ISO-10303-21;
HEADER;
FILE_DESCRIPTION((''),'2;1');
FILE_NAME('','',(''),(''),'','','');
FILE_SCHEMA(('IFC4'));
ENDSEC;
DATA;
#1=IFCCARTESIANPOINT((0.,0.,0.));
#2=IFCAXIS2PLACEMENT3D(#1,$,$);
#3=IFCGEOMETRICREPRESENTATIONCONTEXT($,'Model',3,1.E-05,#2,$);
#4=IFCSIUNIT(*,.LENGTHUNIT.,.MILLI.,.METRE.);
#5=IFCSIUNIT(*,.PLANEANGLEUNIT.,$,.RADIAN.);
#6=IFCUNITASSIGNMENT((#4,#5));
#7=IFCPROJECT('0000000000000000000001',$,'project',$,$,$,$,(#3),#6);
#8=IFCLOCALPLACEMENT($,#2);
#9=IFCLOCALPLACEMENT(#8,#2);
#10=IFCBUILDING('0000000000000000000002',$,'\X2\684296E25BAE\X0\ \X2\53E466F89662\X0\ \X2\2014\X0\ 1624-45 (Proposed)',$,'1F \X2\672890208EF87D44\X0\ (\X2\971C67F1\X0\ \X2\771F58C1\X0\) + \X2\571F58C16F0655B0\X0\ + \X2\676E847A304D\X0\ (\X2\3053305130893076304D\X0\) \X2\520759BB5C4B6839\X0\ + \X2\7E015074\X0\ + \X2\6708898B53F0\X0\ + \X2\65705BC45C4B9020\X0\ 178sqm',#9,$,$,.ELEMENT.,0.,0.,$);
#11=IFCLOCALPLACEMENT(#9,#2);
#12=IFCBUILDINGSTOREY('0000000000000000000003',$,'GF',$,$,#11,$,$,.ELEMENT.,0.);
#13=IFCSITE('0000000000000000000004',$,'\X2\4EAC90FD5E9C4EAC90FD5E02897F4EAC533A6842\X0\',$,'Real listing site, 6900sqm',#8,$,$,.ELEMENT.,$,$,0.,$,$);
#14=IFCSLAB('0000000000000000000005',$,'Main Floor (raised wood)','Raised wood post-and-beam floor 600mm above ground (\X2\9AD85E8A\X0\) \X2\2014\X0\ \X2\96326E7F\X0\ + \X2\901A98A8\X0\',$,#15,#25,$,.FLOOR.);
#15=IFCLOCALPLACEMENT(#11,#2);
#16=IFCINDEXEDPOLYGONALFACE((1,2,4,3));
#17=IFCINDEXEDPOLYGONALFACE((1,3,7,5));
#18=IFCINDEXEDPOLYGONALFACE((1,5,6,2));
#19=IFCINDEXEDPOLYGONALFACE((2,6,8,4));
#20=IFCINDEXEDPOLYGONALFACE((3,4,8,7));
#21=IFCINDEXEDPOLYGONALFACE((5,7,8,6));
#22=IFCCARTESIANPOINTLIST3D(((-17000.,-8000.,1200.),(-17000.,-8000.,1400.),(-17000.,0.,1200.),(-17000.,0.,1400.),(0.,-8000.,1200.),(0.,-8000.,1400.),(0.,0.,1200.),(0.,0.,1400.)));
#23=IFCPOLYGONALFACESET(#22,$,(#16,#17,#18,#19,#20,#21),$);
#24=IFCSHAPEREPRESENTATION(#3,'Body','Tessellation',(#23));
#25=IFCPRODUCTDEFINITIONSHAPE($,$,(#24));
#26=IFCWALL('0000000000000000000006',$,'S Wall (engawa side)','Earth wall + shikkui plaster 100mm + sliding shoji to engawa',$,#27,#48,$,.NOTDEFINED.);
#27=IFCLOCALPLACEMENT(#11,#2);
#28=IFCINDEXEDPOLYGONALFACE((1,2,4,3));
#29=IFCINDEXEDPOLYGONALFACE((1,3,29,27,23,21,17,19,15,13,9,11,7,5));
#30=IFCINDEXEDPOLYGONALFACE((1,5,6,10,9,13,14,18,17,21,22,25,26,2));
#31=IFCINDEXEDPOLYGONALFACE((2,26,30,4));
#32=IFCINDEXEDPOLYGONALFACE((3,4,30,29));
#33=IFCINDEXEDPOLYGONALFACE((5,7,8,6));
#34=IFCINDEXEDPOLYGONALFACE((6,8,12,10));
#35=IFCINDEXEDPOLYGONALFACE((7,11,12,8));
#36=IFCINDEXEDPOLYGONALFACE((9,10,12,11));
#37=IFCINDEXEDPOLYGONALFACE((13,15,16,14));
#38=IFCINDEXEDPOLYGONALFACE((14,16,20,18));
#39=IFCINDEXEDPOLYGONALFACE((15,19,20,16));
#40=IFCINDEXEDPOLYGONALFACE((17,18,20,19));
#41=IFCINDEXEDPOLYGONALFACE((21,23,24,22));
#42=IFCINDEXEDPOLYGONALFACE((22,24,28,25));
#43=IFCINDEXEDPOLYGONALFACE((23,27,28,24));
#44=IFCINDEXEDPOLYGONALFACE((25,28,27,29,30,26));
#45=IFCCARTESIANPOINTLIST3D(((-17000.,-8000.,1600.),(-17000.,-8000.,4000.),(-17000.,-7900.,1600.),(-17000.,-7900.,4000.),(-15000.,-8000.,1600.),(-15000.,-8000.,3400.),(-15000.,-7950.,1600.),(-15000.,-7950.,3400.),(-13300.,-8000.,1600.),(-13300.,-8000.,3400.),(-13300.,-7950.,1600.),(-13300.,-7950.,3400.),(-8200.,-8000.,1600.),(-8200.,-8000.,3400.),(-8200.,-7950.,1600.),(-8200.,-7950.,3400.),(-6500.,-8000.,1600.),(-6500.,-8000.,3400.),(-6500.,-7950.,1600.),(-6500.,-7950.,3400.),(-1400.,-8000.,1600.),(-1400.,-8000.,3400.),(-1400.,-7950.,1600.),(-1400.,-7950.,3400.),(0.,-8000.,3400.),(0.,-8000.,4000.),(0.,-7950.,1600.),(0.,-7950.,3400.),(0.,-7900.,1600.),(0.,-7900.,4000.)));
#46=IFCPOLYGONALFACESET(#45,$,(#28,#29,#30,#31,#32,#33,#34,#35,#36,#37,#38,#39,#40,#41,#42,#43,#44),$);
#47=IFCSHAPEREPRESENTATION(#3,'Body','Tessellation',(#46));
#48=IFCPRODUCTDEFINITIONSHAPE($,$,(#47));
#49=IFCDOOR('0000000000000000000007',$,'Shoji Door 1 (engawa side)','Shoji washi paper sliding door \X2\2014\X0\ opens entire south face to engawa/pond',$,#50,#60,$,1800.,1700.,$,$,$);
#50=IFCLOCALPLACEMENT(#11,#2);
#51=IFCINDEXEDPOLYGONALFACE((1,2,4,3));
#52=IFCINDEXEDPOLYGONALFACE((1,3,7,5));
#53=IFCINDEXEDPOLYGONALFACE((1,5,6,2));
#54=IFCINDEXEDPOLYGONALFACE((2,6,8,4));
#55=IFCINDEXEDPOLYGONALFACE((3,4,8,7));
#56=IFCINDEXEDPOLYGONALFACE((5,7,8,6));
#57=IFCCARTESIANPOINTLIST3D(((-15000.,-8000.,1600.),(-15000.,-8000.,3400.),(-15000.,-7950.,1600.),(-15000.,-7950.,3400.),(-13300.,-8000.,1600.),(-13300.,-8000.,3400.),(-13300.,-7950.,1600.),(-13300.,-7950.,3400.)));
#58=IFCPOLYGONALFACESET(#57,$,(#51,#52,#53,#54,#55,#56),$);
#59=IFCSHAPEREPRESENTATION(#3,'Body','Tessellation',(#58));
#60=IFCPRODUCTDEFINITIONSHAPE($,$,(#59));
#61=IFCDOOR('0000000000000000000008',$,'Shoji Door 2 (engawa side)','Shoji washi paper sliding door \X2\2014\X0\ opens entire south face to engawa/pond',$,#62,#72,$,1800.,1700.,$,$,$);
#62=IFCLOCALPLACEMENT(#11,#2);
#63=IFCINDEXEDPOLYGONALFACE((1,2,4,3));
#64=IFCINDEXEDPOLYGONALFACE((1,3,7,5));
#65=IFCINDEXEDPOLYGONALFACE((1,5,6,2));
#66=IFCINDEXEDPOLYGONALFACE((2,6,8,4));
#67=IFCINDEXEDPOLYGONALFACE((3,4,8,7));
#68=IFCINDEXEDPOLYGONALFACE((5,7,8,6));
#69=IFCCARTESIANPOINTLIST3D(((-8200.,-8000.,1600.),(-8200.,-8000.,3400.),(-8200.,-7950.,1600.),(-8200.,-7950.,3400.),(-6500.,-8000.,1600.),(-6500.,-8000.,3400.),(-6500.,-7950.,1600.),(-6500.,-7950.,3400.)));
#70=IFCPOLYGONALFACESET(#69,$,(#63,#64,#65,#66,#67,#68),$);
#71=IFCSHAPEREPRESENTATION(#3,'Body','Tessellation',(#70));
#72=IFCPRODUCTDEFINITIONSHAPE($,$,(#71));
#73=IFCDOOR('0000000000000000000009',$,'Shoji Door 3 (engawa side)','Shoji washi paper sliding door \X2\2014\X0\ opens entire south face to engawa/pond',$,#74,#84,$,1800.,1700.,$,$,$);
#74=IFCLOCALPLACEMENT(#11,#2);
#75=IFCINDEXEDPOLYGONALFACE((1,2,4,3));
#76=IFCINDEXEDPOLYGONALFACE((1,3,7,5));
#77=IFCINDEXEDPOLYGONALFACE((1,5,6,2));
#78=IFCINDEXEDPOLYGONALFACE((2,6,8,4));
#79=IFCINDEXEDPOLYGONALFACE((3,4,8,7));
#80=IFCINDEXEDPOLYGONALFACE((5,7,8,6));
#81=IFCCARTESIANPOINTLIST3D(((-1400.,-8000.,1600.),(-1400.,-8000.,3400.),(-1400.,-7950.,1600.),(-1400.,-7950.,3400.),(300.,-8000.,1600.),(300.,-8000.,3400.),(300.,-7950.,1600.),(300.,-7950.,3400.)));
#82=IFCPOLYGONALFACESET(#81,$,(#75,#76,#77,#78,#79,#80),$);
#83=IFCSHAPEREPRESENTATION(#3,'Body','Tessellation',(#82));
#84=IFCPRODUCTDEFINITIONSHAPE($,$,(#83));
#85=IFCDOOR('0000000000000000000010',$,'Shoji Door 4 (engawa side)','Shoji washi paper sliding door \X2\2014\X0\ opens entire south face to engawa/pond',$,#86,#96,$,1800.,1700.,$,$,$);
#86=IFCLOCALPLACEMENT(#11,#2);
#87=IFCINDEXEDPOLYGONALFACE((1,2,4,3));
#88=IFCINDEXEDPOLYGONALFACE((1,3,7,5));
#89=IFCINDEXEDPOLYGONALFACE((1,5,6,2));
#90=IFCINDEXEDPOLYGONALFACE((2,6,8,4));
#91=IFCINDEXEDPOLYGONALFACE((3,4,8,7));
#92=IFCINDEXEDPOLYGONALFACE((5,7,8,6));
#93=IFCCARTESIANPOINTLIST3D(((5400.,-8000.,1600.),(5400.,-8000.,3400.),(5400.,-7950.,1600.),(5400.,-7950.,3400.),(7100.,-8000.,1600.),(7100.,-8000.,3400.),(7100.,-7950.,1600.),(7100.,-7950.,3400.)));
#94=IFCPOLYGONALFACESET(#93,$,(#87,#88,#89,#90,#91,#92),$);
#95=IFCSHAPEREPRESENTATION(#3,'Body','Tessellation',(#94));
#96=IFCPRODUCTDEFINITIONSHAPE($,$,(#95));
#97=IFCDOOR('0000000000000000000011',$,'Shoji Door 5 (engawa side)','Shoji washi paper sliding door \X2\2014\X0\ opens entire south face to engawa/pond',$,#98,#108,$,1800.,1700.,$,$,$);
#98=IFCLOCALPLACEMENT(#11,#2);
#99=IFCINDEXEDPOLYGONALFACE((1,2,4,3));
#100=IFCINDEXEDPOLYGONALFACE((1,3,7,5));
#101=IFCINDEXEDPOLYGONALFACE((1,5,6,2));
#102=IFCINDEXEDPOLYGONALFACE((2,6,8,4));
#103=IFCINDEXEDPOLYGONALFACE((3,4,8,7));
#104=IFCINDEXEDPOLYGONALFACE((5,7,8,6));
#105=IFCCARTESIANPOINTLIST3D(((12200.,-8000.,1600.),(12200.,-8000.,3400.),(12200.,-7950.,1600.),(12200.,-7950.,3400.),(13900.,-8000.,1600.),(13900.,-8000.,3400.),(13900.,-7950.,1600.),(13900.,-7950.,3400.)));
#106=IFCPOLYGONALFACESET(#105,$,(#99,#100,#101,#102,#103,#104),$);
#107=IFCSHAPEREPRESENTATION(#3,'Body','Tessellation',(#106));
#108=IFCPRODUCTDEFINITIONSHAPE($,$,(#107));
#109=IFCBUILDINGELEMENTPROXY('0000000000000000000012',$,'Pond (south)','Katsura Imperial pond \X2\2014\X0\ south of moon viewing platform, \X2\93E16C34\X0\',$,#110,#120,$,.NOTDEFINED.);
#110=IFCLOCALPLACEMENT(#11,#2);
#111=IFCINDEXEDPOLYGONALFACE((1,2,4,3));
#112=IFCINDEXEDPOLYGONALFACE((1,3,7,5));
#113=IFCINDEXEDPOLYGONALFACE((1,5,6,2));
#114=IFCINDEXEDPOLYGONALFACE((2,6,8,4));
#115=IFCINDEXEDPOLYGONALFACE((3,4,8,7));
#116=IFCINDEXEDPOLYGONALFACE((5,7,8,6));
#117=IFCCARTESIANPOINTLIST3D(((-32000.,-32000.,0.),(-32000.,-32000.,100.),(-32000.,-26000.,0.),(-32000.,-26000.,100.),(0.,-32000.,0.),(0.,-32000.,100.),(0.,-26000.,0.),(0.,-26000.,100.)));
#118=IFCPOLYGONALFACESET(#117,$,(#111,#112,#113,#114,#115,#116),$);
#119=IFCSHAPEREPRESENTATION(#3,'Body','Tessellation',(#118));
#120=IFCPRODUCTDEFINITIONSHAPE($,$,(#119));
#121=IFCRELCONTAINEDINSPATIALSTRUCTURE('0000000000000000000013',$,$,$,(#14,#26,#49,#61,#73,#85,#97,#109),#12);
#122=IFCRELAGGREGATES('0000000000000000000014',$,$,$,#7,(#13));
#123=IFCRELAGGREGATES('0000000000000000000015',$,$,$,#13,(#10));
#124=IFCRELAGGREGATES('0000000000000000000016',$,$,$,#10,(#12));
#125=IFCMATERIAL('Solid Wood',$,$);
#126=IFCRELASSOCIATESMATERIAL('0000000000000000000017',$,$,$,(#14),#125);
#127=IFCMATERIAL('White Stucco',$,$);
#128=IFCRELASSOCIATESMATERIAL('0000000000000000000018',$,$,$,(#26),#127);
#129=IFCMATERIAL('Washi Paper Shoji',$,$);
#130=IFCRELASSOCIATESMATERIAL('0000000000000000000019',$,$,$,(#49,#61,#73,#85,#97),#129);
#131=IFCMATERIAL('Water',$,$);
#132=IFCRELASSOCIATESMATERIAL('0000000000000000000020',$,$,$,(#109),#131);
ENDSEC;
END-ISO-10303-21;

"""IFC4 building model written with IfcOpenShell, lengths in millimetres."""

from ifc_helpers import new_model, si_unit, frame, frame_2d, origin, place, context, project, spatial, rectangle, extrude, material, element, fill, save


model = new_model("IFC4")

# Units and contexts
model_context = context("Model", 3, precision=1e-05, world=origin())
ifc_project = project(units=[si_unit("LENGTHUNIT", "METRE", prefix="MILLI"), si_unit("PLANEANGLEUNIT", "RADIAN")], contexts=[model_context])

# Site, building, storey
site_placement = place(None, origin())
site = spatial("IfcSite", under=ifc_project, at=site_placement, Name="京都府京都市西京区桂", ObjectType="Real listing site, 6900sqm", CompositionType="ELEMENT", RefElevation=0.0)
building_placement = place(site_placement, origin())
building = spatial("IfcBuilding", under=site, at=building_placement, Name="桂離宮 古書院 — 1624-45 (Proposed)", ObjectType="1F 木造軸組 (霜柱 真壁) + 土壁漆喰 + 杮葺き (こけらぶき) 切妻屋根 + 縁側 + 月見台 + 数寄屋造 178sqm", CompositionType="ELEMENT", ElevationOfRefHeight=0.0, ElevationOfTerrain=0.0)
storey_placement = place(building_placement, origin())
storey = spatial("IfcBuildingStorey", under=building, at=storey_placement, Name="GF", CompositionType="ELEMENT", Elevation=0.0)

# Shared definitions
ifc_material_1 = material(Name="Solid Wood")

# Slab
slab_1_placement = place(storey_placement, frame((-8500.0, -4000.0, 600.0)))
element("IfcSlab", 1, at=slab_1_placement, inside=storey, material=ifc_material_1, Name="Main Floor (raised wood)", Description="Raised wood post-and-beam floor 600mm above ground (高床) — 防湿 + 通風", PredefinedType="FLOOR", context=model_context, shape_type="SweptSolid", body=[
    extrude(rectangle(XDim=17000.0, YDim=8000.0, at=frame_2d((8500.0, 4000.0))), frame((-8500.0, -4000.0, 600.0)), (0.0, 0.0, 1.0), 200.0),
])

# Wall, openings, doors
ifc_material_2 = material(Name="White Stucco")
wall_1_placement = place(storey_placement, frame((-8500.0, -4000.0, 800.0)))
wall_1 = element("IfcWall", 2, at=wall_1_placement, inside=storey, material=ifc_material_2, Name="S Wall (engawa side)", Description="Earth wall + shikkui plaster 100mm + sliding shoji to engawa", PredefinedType="NOTDEFINED", context=model_context, shape_type="SweptSolid", body=[
    extrude(rectangle(XDim=17000.0, YDim=100.0, at=frame_2d((8500.0, 50.0))), frame((-8500.0, -4000.0, 800.0)), (0.0, 0.0, 1.0), 2400.0),
])
opening_1_placement = place(storey_placement, frame((-7500.0, -4000.0, 800.0)))
opening_1 = element("IfcOpeningElement", 3, at=opening_1_placement, cuts=wall_1, PredefinedType="NOTDEFINED", context=model_context, shape_type="SweptSolid", body=[
    extrude(rectangle(XDim=1700.0, YDim=50.0, at=frame_2d((850.0, 25.0))), frame((-7500.0, -4000.0, 800.0)), (0.0, 0.0, 1.0), 1800.0),
])
opening_2_placement = place(storey_placement, frame((-4100.0, -4000.0, 800.0)))
opening_2 = element("IfcOpeningElement", 4, at=opening_2_placement, cuts=wall_1, PredefinedType="NOTDEFINED", context=model_context, shape_type="SweptSolid", body=[
    extrude(rectangle(XDim=1700.0, YDim=50.0, at=frame_2d((850.0, 25.0))), frame((-4100.0, -4000.0, 800.0)), (0.0, 0.0, 1.0), 1800.0),
])
opening_3_placement = place(storey_placement, frame((-700.0, -4000.0, 800.0)))
opening_3 = element("IfcOpeningElement", 5, at=opening_3_placement, cuts=wall_1, PredefinedType="NOTDEFINED", context=model_context, shape_type="SweptSolid", body=[
    extrude(rectangle(XDim=1700.0, YDim=50.0, at=frame_2d((850.0, 25.0))), frame((-700.0, -4000.0, 800.0)), (0.0, 0.0, 1.0), 1800.0),
])
opening_4_placement = place(storey_placement, frame((2700.0, -4000.0, 800.0)))
opening_4 = element("IfcOpeningElement", 6, at=opening_4_placement, cuts=wall_1, PredefinedType="NOTDEFINED", context=model_context, shape_type="SweptSolid", body=[
    extrude(rectangle(XDim=1700.0, YDim=50.0, at=frame_2d((850.0, 25.0))), frame((2700.0, -4000.0, 800.0)), (0.0, 0.0, 1.0), 1800.0),
])
opening_5_placement = place(storey_placement, frame((6100.0, -4000.0, 800.0)))
opening_5 = element("IfcOpeningElement", 7, at=opening_5_placement, cuts=wall_1, PredefinedType="NOTDEFINED", context=model_context, shape_type="SweptSolid", body=[
    extrude(rectangle(XDim=1700.0, YDim=50.0, at=frame_2d((850.0, 25.0))), frame((6100.0, -4000.0, 800.0)), (0.0, 0.0, 1.0), 1800.0),
])
ifc_material_3 = material(Name="Washi Paper Shoji")
door_1_placement = place(storey_placement, frame((-7500.0, -4000.0, 800.0)))
door_1 = element("IfcDoor", 8, at=door_1_placement, inside=storey, material=ifc_material_3, Name="Shoji Door 1 (engawa side)", Description="Shoji washi paper sliding door — opens entire south face to engawa/pond", OverallHeight=1800.0, OverallWidth=1700.0, context=model_context, shape_type="SweptSolid", body=[
    extrude(rectangle(XDim=1700.0, YDim=50.0, at=frame_2d((850.0, 25.0))), frame((-7500.0, -4000.0, 800.0)), (0.0, 0.0, 1.0), 1800.0),
])
fill(opening_1, door_1)
door_2_placement = place(storey_placement, frame((-4100.0, -4000.0, 800.0)))
door_2 = element("IfcDoor", 9, at=door_2_placement, inside=storey, material=ifc_material_3, Name="Shoji Door 2 (engawa side)", Description="Shoji washi paper sliding door — opens entire south face to engawa/pond", OverallHeight=1800.0, OverallWidth=1700.0, context=model_context, shape_type="SweptSolid", body=[
    extrude(rectangle(XDim=1700.0, YDim=50.0, at=frame_2d((850.0, 25.0))), frame((-4100.0, -4000.0, 800.0)), (0.0, 0.0, 1.0), 1800.0),
])
fill(opening_2, door_2)
door_3_placement = place(storey_placement, frame((-700.0, -4000.0, 800.0)))
door_3 = element("IfcDoor", 10, at=door_3_placement, inside=storey, material=ifc_material_3, Name="Shoji Door 3 (engawa side)", Description="Shoji washi paper sliding door — opens entire south face to engawa/pond", OverallHeight=1800.0, OverallWidth=1700.0, context=model_context, shape_type="SweptSolid", body=[
    extrude(rectangle(XDim=1700.0, YDim=50.0, at=frame_2d((850.0, 25.0))), frame((-700.0, -4000.0, 800.0)), (0.0, 0.0, 1.0), 1800.0),
])
fill(opening_3, door_3)
door_4_placement = place(storey_placement, frame((2700.0, -4000.0, 800.0)))
door_4 = element("IfcDoor", 11, at=door_4_placement, inside=storey, material=ifc_material_3, Name="Shoji Door 4 (engawa side)", Description="Shoji washi paper sliding door — opens entire south face to engawa/pond", OverallHeight=1800.0, OverallWidth=1700.0, context=model_context, shape_type="SweptSolid", body=[
    extrude(rectangle(XDim=1700.0, YDim=50.0, at=frame_2d((850.0, 25.0))), frame((2700.0, -4000.0, 800.0)), (0.0, 0.0, 1.0), 1800.0),
])
fill(opening_4, door_4)
door_5_placement = place(storey_placement, frame((6100.0, -4000.0, 800.0)))
door_5 = element("IfcDoor", 12, at=door_5_placement, inside=storey, material=ifc_material_3, Name="Shoji Door 5 (engawa side)", Description="Shoji washi paper sliding door — opens entire south face to engawa/pond", OverallHeight=1800.0, OverallWidth=1700.0, context=model_context, shape_type="SweptSolid", body=[
    extrude(rectangle(XDim=1700.0, YDim=50.0, at=frame_2d((850.0, 25.0))), frame((6100.0, -4000.0, 800.0)), (0.0, 0.0, 1.0), 1800.0),
])
fill(opening_5, door_5)

# Building element proxy
ifc_material_4 = material(Name="Water")
proxy_1_placement = place(storey_placement, frame((-16000.0, -16000.0, 0.0)))
element("IfcBuildingElementProxy", 13, at=proxy_1_placement, inside=storey, material=ifc_material_4, Name="Pond (south)", Description="Katsura Imperial pond — south of moon viewing platform, 鏡水", PredefinedType="NOTDEFINED", context=model_context, shape_type="SweptSolid", body=[
    extrude(rectangle(XDim=32000.0, YDim=6000.0, at=frame_2d((16000.0, 3000.0))), frame((-16000.0, -16000.0, 0.0)), (0.0, 0.0, 1.0), 100.0),
])

save(model, "model.ifc")
